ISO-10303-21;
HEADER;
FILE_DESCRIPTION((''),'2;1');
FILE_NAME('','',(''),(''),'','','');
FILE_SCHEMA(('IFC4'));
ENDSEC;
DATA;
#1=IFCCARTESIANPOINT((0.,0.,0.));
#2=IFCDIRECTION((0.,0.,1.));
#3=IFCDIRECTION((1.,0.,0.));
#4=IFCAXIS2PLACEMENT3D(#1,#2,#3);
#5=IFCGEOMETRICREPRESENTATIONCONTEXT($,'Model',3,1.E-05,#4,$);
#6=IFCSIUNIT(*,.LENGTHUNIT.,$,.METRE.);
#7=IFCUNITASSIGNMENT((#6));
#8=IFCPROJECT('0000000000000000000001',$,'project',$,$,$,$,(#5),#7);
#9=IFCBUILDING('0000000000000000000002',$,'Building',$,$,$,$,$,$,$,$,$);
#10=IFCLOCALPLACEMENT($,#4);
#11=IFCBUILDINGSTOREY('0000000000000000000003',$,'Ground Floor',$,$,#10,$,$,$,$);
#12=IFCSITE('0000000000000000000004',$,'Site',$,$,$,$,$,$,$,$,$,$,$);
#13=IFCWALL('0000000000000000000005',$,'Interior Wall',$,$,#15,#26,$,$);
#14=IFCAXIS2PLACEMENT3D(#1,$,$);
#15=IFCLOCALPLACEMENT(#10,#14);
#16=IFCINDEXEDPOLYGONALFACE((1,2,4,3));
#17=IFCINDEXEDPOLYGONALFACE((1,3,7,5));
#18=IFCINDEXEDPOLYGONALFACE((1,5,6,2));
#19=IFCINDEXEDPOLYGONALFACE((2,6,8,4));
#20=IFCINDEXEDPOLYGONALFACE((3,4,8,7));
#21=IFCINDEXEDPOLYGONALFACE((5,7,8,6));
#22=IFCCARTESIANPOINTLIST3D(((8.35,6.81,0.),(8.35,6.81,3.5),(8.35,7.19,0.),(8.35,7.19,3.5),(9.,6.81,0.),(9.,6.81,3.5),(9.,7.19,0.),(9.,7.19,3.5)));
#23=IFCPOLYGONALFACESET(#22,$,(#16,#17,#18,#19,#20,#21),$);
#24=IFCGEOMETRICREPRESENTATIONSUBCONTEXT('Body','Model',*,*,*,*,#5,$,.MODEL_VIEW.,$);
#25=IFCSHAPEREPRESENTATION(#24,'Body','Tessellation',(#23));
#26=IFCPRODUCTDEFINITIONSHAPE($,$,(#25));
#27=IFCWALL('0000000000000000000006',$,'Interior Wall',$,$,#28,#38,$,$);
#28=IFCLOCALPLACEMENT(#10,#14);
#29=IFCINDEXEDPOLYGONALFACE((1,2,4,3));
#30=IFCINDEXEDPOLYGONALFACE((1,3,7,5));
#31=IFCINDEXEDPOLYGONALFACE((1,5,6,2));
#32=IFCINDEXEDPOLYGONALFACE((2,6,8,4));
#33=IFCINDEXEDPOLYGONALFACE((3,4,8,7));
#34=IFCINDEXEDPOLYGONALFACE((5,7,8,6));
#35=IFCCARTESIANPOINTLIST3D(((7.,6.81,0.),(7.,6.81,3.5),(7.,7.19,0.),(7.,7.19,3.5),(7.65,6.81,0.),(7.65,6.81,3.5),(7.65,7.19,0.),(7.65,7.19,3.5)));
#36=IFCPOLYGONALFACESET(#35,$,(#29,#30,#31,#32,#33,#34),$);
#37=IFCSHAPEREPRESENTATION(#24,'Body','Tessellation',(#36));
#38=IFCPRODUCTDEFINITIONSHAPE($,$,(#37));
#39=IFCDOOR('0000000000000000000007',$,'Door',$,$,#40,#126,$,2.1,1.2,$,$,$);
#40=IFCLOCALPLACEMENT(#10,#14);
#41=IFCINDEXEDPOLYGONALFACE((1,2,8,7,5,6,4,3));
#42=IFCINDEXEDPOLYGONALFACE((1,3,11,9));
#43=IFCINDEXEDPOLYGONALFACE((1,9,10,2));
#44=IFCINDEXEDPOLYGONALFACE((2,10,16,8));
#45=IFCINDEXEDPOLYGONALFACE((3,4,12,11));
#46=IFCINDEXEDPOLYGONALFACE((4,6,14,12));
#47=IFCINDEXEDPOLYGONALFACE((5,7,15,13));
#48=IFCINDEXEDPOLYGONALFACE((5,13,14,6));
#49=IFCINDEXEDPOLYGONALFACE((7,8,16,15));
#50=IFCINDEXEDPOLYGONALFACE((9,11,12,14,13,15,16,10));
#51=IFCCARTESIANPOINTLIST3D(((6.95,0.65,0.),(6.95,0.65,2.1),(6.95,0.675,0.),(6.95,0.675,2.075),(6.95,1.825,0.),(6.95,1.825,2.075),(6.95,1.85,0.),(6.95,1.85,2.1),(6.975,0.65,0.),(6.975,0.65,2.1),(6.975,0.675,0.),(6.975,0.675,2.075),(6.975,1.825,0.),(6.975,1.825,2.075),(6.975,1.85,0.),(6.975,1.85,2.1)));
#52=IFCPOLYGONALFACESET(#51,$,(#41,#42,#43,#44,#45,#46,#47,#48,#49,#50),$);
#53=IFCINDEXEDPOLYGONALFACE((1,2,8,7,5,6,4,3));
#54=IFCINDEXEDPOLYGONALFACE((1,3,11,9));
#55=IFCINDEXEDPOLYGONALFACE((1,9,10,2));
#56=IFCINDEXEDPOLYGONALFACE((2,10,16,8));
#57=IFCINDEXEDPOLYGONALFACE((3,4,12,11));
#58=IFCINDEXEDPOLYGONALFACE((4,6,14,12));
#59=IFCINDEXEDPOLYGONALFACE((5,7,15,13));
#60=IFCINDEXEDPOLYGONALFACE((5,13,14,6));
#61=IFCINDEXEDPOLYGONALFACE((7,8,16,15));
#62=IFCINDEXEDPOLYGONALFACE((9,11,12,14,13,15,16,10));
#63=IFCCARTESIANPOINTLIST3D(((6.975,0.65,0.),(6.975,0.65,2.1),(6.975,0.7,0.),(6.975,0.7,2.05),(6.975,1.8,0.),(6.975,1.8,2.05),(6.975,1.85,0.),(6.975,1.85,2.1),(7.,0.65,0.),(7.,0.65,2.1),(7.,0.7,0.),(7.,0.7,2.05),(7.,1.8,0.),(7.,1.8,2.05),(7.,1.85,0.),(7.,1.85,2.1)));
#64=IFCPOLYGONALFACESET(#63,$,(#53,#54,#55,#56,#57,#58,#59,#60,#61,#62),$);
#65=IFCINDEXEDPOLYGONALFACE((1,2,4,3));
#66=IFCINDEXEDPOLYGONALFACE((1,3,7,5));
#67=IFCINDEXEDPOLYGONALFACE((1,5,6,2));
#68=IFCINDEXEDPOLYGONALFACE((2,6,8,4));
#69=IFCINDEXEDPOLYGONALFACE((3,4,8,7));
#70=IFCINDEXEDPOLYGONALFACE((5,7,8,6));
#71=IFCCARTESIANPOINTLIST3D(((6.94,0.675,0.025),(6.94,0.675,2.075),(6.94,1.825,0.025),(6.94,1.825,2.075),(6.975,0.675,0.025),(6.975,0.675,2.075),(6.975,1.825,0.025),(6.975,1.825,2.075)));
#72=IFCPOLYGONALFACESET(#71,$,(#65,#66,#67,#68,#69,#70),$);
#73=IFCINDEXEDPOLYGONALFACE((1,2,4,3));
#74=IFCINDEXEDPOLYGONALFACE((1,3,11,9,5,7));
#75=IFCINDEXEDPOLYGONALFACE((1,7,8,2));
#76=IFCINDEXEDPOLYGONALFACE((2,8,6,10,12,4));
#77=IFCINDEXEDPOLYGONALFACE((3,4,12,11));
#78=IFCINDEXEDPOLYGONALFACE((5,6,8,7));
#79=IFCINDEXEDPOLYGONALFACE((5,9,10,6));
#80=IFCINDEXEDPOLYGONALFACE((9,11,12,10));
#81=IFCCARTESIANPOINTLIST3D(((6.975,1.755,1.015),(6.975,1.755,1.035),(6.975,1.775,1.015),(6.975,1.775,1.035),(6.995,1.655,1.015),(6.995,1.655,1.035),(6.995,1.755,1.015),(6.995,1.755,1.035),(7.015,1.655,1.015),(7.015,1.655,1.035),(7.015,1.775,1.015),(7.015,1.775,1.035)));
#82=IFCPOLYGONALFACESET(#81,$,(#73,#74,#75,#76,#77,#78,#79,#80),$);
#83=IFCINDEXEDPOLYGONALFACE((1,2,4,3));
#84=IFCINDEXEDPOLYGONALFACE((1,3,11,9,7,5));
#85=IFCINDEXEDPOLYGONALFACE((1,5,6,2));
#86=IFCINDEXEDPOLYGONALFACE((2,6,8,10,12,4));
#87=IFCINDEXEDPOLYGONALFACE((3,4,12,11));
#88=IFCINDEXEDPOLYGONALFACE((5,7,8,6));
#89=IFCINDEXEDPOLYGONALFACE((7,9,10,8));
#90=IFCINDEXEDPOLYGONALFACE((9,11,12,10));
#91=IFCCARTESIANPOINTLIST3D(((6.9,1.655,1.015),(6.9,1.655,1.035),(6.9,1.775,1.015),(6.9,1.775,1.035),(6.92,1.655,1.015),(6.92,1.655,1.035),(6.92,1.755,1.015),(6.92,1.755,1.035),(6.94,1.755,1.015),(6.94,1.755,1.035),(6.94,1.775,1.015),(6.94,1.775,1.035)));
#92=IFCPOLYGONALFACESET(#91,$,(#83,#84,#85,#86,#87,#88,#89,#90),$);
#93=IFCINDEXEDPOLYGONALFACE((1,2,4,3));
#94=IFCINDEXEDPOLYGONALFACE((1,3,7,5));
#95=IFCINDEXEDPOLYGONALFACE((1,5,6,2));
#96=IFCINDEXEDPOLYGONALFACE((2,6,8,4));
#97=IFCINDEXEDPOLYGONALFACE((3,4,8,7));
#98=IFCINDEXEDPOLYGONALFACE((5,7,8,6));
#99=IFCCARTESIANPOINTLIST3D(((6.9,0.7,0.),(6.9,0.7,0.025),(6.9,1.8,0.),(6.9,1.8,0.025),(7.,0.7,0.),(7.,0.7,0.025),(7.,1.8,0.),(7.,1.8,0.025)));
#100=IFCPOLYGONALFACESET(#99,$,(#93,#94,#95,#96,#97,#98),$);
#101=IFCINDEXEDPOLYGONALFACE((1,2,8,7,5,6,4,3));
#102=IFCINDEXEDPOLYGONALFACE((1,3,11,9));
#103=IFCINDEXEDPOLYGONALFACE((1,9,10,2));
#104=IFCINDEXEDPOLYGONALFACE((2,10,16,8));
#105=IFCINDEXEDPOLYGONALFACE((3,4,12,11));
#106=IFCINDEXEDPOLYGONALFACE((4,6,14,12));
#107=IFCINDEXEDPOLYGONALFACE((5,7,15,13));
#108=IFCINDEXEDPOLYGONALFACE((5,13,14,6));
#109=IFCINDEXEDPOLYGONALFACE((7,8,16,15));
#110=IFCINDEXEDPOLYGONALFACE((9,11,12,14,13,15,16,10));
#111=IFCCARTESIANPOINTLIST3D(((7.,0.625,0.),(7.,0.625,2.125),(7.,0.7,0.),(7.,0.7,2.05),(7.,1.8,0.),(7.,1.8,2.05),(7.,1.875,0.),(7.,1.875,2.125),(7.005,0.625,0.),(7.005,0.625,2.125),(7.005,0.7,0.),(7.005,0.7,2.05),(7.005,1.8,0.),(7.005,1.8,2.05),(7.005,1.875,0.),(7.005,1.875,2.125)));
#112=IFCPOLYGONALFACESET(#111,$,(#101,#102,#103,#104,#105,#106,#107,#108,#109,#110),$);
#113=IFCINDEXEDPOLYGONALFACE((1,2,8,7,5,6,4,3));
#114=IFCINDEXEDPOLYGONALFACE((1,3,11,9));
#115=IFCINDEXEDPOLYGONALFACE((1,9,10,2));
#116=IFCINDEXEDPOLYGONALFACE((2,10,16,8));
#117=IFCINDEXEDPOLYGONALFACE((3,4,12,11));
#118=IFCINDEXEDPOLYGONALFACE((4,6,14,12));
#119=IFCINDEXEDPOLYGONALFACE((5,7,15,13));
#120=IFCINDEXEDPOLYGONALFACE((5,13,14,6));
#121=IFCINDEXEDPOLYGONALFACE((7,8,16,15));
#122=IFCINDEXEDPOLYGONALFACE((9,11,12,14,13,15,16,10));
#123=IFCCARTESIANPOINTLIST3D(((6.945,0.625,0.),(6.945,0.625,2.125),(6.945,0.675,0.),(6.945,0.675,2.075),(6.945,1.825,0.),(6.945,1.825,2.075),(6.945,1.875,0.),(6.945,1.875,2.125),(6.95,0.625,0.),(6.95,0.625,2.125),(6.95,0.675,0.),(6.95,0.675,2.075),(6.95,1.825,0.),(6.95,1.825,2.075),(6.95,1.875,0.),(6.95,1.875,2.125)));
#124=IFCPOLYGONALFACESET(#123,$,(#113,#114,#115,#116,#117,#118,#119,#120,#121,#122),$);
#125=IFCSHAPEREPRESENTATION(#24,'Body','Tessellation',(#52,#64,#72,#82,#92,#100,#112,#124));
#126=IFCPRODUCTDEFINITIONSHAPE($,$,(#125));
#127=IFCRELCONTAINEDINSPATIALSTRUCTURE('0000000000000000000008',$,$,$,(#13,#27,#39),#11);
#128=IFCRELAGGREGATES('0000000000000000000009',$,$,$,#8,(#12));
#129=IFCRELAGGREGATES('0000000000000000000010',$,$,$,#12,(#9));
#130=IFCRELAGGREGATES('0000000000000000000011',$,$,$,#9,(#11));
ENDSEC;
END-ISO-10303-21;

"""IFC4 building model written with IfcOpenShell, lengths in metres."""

from ifc_helpers import new_model, si_unit, frame, origin_with_axes, place, context, subcontext, project, spatial, line, indexed_curve, outline, extrude, element, save


model = new_model("IFC4")

# Units and contexts
model_context = context("Model", 3, precision=1e-05, world=origin_with_axes())
body_context = subcontext(model_context, "Body", "Model", "MODEL_VIEW")
ifc_project = project(units=[si_unit("LENGTHUNIT", "METRE")], contexts=[model_context])

# Site, building, storey
site = spatial("IfcSite", under=ifc_project, Name="Site")
building = spatial("IfcBuilding", under=site, Name="Building")
storey_placement = place(None, origin_with_axes())
storey = spatial("IfcBuildingStorey", under=building, at=storey_placement, Name="Ground Floor")

# Walls
for number, where, z_axis, x_axis, name in (
    (1, (9.0, 7.0, 0.0), (0.0, 0.0, 1.0), (-1.0, 0.0, 0.0), "Interior Wall"),
    (2, (7.65, 7.0, 0.0), (0.0, 0.0, 1.0), (-1.0, 0.0, 0.0), "Interior Wall"),
):
    element("IfcWall", number, at=place(storey_placement, frame(where, z_axis=z_axis, x_axis=x_axis)), inside=storey, Name=name, context=body_context, shape_type="SweptSolid", body=[
        extrude(outline(indexed_curve([(0.0, 0.0), (0.0, 0.38), (0.65, 0.38), (0.65, 0.0), (0.0, 0.0)], self_intersect=False)), frame((0.0, -0.19, 0.0), z_axis=(0.0, 0.0, 1.0), x_axis=(1.0, 0.0, 0.0)), (0.0, 0.0, 1.0), 3.5),
    ])

# Door
door_1_placement = place(storey_placement, frame((7.0, 0.65, 0.0), z_axis=(0.0, 0.0, 1.0), x_axis=(0.0, 1.0, 0.0)))
element("IfcDoor", 3, at=door_1_placement, inside=storey, Name="Door", OverallHeight=2.1, OverallWidth=1.2, context=body_context, shape_type="SweptSolid", body=[
    extrude(outline(indexed_curve([(0.0, 0.0), (0.0, 2.1), (1.2, 2.1), (1.2, 0.0), (1.175, 0.0), (1.175, 2.075), (0.025, 2.075), (0.025, 0.0)], segments=[line(1, 2, 3, 4, 5, 6, 7, 8, 1)])), frame((0.0, 0.025, 0.0), z_axis=(0.0, -1.0, 0.0), x_axis=(1.0, 0.0, 0.0)), (0.0, 0.0, -1.0), 0.025),
    extrude(outline(indexed_curve([(0.0, 0.0), (0.0, 2.1), (1.2, 2.1), (1.2, 0.0), (1.15, 0.0), (1.15, 2.05), (0.05, 2.05), (0.05, 0.0)], segments=[line(1, 2, 3, 4, 5, 6, 7, 8, 1)])), frame((0.0, 0.0, 0.0), z_axis=(0.0, -1.0, 0.0), x_axis=(1.0, 0.0, 0.0)), (0.0, 0.0, -1.0), 0.025),
    extrude(outline(indexed_curve([(0.0, 0.0), (1.15, 0.0), (1.15, 0.035), (0.0, 0.035)], segments=[line(1, 2, 3, 4, 1)])), frame((0.025, 0.025, 0.025), z_axis=(0.0, 0.0, 1.0), x_axis=(1.0, 0.0, 0.0)), (0.0, 0.0, 1.0), 2.05),
    extrude(outline(indexed_curve([(0.0, 0.0), (0.0, -0.04), (-0.12, -0.04), (-0.12, -0.02), (-0.02, -0.02), (-0.02, 0.0)], segments=[line(1, 2, 3, 4, 5, 6, 1)])), frame((1.125, 0.025, 1.015), z_axis=(0.0, 0.0, 1.0), x_axis=(1.0, 0.0, 0.0)), (0.0, 0.0, 1.0), 0.02),
    extrude(outline(indexed_curve([(0.0, 0.0), (0.0, 0.04), (-0.12, 0.04), (-0.12, 0.02), (-0.02, 0.02), (-0.02, 0.0)], segments=[line(1, 2, 3, 4, 5, 6, 1)])), frame((1.125, 0.06, 1.015), z_axis=(0.0, 0.0, 1.0), x_axis=(1.0, 0.0, 0.0)), (0.0, 0.0, 1.0), 0.02),
    extrude(outline(indexed_curve([(0.0, 0.0), (1.1, 0.0), (1.1, 0.1), (0.0, 0.1)], segments=[line(1, 2, 3, 4, 1)])), frame((0.05, 0.0, 0.0), z_axis=(0.0, 0.0, 1.0), x_axis=(1.0, 0.0, 0.0)), (0.0, 0.0, 1.0), 0.025),
    extrude(outline(indexed_curve([(0.0, 0.0), (0.0, 2.125), (1.25, 2.125), (1.25, 0.0), (1.175, 0.0), (1.175, 2.05), (0.075, 2.05), (0.075, 0.0)], segments=[line(1, 2, 3, 4, 5, 6, 7, 8, 1)])), frame((-0.025, -0.005, 0.0), z_axis=(0.0, -1.0, 0.0), x_axis=(1.0, 0.0, 0.0)), (0.0, 0.0, -1.0), 0.005),
    extrude(outline(indexed_curve([(0.0, 0.0), (0.0, 2.125), (1.25, 2.125), (1.25, 0.0), (1.2, 0.0), (1.2, 2.075), (0.05, 2.075), (0.05, 0.0)], segments=[line(1, 2, 3, 4, 5, 6, 7, 8, 1)])), frame((-0.025, 0.05, 0.0), z_axis=(0.0, -1.0, 0.0), x_axis=(1.0, 0.0, 0.0)), (0.0, 0.0, -1.0), 0.005),
])

save(model, "model.ifc")
